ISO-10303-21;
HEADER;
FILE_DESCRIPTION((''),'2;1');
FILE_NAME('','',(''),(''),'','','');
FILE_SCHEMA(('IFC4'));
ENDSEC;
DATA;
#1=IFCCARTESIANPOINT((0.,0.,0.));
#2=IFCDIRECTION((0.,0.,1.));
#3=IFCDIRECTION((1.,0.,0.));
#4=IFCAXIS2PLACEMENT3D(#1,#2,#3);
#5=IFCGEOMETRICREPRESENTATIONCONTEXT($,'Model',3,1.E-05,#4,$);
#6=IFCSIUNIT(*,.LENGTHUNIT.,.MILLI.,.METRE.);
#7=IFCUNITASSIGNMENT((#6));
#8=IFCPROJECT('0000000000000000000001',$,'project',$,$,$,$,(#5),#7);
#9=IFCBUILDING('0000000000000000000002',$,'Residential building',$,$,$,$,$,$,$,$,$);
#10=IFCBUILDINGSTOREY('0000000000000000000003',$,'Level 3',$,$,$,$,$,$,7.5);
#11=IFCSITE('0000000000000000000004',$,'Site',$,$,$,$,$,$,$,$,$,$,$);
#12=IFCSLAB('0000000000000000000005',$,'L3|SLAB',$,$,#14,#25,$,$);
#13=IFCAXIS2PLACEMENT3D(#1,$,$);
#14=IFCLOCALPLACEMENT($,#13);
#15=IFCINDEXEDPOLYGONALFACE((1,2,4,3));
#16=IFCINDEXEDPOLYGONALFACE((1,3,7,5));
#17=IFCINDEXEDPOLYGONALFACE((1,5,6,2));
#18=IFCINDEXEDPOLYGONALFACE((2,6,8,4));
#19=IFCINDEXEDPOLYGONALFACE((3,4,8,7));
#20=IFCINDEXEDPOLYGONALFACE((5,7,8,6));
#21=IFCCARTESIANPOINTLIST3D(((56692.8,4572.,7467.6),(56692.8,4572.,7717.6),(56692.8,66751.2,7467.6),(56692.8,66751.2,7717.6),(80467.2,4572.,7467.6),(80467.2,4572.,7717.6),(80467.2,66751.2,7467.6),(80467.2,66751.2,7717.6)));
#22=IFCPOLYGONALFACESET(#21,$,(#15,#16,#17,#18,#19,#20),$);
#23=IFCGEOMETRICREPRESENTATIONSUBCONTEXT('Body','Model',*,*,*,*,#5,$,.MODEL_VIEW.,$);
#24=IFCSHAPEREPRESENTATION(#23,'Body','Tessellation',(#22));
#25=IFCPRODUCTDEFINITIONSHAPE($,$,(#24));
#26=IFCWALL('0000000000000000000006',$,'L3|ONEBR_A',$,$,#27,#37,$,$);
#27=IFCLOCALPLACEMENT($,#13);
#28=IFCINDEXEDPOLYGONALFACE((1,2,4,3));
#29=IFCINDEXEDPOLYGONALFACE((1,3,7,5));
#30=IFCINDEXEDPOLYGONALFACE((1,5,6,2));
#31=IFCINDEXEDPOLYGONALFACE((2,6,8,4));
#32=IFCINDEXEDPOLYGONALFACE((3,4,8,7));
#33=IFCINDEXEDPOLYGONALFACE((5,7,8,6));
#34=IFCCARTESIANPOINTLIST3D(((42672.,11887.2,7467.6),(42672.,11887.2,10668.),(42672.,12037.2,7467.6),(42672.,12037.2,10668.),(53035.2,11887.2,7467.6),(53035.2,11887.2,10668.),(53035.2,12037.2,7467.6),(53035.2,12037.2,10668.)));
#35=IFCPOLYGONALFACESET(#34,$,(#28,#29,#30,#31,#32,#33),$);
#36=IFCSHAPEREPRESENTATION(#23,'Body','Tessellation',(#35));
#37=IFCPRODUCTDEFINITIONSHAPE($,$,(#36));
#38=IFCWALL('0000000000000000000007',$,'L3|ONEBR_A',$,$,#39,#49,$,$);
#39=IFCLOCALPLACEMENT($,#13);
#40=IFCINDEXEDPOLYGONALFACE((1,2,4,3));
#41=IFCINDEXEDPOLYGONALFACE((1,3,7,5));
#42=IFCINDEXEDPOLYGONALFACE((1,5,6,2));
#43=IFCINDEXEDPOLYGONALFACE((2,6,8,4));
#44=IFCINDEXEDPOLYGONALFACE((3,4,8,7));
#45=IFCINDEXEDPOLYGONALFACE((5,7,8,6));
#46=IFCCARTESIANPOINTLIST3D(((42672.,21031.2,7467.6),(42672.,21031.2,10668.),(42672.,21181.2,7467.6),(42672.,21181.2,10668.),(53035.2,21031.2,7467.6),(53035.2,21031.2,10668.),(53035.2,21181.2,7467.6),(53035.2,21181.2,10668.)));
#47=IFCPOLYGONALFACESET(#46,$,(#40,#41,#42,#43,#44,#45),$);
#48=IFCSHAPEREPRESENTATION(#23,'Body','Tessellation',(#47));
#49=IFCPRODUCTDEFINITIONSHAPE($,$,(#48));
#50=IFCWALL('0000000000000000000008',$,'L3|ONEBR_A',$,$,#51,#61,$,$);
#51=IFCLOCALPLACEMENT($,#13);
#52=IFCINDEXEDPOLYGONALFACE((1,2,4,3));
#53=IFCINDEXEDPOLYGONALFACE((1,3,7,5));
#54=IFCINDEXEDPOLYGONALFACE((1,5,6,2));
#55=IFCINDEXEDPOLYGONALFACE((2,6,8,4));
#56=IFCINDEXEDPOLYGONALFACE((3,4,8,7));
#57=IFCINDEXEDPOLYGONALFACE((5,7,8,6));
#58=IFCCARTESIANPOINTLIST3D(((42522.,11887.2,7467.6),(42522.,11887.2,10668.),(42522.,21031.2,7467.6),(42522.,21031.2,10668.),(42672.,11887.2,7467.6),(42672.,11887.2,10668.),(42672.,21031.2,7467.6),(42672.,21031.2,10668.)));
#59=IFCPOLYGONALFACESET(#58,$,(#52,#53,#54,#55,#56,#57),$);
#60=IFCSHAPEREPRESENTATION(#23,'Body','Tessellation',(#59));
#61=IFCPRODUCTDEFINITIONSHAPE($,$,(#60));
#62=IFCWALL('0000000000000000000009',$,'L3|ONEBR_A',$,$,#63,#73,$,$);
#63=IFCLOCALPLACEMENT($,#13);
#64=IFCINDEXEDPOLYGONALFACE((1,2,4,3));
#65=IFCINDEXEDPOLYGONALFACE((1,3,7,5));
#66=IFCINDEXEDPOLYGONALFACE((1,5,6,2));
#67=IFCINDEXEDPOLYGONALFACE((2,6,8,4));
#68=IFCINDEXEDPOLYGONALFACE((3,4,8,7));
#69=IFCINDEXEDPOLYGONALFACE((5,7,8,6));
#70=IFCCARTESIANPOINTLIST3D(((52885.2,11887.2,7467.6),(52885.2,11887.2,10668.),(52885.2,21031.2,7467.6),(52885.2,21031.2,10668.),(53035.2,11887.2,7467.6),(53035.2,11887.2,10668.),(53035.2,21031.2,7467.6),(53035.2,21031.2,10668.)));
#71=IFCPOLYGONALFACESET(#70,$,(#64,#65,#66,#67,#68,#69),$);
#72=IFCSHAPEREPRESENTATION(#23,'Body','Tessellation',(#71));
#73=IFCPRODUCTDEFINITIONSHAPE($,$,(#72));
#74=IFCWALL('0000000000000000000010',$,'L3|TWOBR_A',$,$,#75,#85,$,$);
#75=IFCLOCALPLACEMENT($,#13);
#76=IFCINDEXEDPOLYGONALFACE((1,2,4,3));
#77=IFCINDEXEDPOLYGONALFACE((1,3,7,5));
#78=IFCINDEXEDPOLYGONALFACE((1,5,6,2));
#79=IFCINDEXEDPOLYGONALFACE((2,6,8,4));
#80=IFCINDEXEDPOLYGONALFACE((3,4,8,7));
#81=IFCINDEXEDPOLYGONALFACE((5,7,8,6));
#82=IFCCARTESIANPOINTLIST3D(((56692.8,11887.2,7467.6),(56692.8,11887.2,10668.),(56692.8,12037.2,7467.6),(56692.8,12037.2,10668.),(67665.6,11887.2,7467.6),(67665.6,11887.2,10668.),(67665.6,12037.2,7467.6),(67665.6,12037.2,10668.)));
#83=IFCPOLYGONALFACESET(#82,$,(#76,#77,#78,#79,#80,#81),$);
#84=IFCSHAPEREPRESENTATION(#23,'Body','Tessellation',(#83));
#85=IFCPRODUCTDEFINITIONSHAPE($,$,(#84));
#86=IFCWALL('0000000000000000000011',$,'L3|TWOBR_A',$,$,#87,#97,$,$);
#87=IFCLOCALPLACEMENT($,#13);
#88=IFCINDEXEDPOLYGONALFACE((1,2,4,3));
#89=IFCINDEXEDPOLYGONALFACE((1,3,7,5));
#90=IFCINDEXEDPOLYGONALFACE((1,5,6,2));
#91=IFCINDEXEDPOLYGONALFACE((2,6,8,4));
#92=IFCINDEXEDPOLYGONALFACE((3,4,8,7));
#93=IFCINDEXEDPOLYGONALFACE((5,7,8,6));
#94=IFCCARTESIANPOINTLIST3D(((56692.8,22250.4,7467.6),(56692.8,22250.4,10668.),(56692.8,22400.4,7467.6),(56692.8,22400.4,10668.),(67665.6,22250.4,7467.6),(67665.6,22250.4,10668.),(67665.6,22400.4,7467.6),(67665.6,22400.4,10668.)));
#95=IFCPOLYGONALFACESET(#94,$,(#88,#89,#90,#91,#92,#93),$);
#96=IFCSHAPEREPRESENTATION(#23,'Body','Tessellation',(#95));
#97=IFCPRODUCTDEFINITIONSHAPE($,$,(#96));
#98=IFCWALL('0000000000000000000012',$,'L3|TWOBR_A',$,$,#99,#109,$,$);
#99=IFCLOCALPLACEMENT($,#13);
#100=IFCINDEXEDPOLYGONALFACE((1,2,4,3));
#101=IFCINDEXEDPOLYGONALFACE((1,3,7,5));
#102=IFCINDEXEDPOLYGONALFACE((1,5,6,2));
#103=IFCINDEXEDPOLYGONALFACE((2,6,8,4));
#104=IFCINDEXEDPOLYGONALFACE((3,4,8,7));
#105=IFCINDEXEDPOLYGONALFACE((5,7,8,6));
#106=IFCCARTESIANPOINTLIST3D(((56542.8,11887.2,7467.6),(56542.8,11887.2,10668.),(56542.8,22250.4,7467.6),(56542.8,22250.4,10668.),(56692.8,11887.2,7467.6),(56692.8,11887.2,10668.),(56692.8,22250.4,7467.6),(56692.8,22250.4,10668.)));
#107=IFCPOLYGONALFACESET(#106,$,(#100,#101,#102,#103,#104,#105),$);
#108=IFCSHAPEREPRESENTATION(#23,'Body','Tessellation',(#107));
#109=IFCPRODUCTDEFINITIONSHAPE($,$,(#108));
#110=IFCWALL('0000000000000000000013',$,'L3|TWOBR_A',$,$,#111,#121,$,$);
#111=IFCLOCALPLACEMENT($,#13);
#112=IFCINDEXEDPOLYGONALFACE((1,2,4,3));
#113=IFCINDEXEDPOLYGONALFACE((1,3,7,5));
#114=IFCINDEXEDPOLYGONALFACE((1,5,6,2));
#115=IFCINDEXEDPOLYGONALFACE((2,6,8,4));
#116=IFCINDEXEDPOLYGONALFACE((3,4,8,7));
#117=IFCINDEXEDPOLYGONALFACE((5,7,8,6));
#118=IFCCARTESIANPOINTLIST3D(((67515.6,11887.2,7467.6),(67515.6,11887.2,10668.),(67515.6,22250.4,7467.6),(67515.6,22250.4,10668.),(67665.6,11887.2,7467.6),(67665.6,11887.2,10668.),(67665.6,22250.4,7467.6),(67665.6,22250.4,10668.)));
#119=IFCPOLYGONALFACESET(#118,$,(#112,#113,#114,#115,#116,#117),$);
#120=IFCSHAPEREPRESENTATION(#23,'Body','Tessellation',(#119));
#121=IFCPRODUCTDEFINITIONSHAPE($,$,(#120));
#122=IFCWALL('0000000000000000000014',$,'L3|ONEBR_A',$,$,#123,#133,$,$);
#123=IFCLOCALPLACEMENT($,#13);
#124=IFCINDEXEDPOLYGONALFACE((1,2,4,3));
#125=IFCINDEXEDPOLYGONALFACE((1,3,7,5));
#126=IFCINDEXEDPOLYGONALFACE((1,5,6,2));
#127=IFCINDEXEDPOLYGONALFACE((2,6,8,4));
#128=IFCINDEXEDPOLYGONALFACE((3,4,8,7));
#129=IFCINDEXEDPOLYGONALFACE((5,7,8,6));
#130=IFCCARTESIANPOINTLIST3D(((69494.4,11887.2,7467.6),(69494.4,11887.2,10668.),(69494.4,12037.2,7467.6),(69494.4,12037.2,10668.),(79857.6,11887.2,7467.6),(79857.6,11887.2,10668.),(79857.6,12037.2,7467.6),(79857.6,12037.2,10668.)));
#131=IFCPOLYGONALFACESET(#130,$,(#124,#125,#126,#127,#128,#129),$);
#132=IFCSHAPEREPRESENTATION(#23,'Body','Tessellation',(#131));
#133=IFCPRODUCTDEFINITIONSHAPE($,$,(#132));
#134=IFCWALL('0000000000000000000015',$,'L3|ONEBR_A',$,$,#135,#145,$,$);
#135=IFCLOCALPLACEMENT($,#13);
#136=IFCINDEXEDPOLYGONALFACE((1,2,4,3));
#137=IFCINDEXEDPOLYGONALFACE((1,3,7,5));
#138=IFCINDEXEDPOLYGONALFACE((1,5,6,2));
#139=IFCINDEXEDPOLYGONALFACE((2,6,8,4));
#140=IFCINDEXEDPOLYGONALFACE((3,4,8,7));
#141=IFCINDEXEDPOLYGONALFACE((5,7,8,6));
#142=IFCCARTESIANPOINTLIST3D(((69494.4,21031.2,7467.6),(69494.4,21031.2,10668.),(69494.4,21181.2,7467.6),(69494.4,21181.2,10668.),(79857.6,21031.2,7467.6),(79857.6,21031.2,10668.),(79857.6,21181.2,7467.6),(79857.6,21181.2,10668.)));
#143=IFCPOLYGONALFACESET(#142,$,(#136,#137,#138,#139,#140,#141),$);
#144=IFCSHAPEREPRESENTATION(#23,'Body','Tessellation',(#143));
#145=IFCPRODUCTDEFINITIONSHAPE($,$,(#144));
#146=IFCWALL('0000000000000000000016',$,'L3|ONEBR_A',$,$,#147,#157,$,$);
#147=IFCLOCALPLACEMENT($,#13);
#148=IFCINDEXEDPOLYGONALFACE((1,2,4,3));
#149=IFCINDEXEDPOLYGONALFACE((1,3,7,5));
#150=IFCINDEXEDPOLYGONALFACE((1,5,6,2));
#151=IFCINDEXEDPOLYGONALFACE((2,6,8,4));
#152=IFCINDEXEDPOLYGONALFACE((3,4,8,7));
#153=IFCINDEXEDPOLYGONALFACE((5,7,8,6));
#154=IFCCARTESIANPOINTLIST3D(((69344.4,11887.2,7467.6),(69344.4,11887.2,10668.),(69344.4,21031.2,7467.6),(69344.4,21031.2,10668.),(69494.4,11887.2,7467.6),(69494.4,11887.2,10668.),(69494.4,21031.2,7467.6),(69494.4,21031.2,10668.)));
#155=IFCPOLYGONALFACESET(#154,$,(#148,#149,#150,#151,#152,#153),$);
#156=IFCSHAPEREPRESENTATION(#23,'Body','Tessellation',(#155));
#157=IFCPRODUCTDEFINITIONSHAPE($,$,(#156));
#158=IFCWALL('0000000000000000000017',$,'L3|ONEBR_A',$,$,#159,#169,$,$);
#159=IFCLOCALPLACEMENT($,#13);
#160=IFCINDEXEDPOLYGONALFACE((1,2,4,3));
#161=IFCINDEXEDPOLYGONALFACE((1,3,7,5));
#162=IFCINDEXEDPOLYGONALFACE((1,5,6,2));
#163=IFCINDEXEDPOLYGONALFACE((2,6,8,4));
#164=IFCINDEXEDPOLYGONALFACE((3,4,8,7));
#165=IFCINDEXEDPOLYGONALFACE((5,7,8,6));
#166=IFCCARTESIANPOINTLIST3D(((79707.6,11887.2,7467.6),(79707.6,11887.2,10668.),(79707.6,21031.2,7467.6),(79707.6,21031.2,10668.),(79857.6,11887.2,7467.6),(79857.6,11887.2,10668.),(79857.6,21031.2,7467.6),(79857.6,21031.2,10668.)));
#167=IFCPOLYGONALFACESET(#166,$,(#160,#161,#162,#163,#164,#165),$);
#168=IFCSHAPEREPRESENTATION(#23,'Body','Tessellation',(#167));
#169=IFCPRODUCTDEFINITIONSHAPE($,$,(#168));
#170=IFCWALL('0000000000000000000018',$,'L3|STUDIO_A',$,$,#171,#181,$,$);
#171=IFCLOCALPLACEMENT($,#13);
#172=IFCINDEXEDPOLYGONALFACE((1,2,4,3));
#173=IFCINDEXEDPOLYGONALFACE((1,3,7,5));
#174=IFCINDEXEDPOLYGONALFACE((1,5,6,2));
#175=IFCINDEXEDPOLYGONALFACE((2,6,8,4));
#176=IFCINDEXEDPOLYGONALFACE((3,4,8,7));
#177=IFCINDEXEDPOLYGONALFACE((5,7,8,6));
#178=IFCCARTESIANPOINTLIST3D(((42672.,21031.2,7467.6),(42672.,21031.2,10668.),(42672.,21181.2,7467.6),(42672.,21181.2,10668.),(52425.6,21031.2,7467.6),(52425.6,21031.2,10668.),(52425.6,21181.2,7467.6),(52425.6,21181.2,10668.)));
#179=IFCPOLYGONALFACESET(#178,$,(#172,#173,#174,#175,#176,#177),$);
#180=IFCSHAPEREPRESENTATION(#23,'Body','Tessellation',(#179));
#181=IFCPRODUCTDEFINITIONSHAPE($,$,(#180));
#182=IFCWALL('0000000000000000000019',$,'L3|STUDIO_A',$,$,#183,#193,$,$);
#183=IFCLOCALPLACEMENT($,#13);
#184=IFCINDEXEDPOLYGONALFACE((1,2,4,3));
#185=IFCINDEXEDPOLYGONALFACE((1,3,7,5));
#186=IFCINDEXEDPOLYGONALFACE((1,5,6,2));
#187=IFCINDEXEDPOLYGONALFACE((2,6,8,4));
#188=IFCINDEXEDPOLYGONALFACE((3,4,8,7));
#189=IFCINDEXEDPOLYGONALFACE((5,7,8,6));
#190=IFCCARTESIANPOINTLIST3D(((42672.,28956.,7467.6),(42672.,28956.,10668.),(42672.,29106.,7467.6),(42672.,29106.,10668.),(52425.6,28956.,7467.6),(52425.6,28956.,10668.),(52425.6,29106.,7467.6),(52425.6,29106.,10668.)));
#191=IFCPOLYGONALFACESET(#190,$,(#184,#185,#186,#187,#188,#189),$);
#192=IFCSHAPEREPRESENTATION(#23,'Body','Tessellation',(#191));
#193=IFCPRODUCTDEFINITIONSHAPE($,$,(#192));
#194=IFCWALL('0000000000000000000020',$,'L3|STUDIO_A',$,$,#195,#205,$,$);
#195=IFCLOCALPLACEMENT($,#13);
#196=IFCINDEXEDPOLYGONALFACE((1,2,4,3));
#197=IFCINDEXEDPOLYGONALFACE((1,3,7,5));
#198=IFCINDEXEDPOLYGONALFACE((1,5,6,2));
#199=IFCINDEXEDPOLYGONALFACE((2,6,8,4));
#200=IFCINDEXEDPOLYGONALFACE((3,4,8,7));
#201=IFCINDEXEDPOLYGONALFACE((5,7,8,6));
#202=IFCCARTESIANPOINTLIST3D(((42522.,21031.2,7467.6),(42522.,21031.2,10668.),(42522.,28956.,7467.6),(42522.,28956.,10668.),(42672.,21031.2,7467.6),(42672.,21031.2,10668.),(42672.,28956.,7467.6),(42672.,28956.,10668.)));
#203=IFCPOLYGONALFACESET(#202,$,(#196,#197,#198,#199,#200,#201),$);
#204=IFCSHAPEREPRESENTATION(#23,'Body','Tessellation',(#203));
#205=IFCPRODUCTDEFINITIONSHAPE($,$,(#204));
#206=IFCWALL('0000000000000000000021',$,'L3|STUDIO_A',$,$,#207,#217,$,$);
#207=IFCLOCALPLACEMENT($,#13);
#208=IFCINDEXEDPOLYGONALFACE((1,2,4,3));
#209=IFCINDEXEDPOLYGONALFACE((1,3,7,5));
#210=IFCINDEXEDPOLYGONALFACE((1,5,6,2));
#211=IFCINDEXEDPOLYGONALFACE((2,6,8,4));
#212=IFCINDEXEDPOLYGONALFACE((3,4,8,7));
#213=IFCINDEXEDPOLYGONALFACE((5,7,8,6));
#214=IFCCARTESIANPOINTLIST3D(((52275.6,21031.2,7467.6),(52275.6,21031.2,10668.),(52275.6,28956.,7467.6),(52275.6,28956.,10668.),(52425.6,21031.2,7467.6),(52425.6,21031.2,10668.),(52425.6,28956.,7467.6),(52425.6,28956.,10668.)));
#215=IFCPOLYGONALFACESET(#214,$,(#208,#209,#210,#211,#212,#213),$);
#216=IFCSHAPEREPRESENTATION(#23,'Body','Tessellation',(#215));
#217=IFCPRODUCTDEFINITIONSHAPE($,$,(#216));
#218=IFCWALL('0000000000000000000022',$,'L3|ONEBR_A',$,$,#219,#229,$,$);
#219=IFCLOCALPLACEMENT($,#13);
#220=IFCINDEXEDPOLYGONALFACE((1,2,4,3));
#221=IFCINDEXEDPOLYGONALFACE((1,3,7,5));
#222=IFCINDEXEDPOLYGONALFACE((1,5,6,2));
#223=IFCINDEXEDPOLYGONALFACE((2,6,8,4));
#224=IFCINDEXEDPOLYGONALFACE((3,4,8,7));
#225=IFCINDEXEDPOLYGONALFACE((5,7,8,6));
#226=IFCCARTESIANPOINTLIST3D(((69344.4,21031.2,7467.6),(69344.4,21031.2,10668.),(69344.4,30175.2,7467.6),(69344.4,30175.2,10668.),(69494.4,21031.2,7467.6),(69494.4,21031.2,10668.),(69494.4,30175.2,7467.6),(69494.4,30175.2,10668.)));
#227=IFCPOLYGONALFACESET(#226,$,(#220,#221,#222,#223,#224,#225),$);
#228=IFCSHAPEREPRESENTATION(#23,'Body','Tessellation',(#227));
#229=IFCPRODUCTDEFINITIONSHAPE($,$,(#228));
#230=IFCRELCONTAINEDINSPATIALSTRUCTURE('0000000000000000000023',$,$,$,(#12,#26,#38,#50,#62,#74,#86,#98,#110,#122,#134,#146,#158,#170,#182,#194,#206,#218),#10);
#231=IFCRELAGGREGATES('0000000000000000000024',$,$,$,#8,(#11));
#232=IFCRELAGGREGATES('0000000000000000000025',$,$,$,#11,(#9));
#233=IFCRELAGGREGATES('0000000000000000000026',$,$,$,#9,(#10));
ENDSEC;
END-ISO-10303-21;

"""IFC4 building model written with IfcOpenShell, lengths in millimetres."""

from ifc_helpers import new_model, si_unit, frame, origin_with_axes, place, context, subcontext, project, spatial, indexed_curve, outline, extrude, element, save


model = new_model("IFC4")

# Units and contexts
model_context = context("Model", 3, precision=1e-05, world=origin_with_axes())
body_context = subcontext(model_context, "Body", "Model", "MODEL_VIEW")
ifc_project = project(units=[si_unit("LENGTHUNIT", "METRE", prefix="MILLI")], contexts=[model_context])

# Site, building, storey
site = spatial("IfcSite", under=ifc_project, Name="Site")
building = spatial("IfcBuilding", under=site, Name="Residential building")
storey = spatial("IfcBuildingStorey", under=building, Name="Level 3", Elevation=7.5)

# Slab
slab_placement = place(None, frame((56692.8, 4572.0, 7467.6), z_axis=(0.0, 0.0, 1.0), x_axis=(1.0, 0.0, 0.0)))
element("IfcSlab", 1, at=slab_placement, inside=storey, Name="L3|SLAB", context=body_context, shape_type="SweptSolid", body=[
    extrude(outline(indexed_curve([(0.0, 0.0), (23774.4, 0.0), (23774.4, 62179.2), (0.0, 62179.2), (0.0, 0.0)])), None, (0.0, 0.0, 1.0), 250.0),
])

# Walls
for number, where, z_axis, x_axis, name in (
    (2, (42672.0, 11887.2, 7467.6), (0.0, 0.0, 1.0), (1.0, 0.0, 0.0), "L3|ONEBR_A"),
    (3, (42672.0, 21031.2, 7467.6), (0.0, 0.0, 1.0), (1.0, 0.0, 0.0), "L3|ONEBR_A"),
):
    element("IfcWall", number, at=place(None, frame(where, z_axis=z_axis, x_axis=x_axis)), inside=storey, Name=name, context=body_context, shape_type="SweptSolid", body=[
        extrude(outline(indexed_curve([(0.0, 0.0), (0.0, 150.0), (10363.2, 150.0), (10363.2, 0.0), (0.0, 0.0)], self_intersect=False)), origin_with_axes(), (0.0, 0.0, 1.0), 3200.4),
    ])
for number, where, z_axis, x_axis, name in (
    (4, (42672.0, 11887.2, 7467.6), (0.0, 0.0, 1.0), (0.0, 1.0, 0.0), "L3|ONEBR_A"),
    (5, (53035.2, 11887.2, 7467.6), (0.0, 0.0, 1.0), (0.0, 1.0, 0.0), "L3|ONEBR_A"),
):
    element("IfcWall", number, at=place(None, frame(where, z_axis=z_axis, x_axis=x_axis)), inside=storey, Name=name, context=body_context, shape_type="SweptSolid", body=[
        extrude(outline(indexed_curve([(0.0, 0.0), (0.0, 150.0), (9144.0, 150.0), (9144.0, 0.0), (0.0, 0.0)], self_intersect=False)), origin_with_axes(), (0.0, 0.0, 1.0), 3200.4),
    ])
for number, where, z_axis, x_axis, name in (
    (6, (56692.8, 11887.2, 7467.6), (0.0, 0.0, 1.0), (1.0, 0.0, 0.0), "L3|TWOBR_A"),
    (7, (56692.8, 22250.4, 7467.6), (0.0, 0.0, 1.0), (1.0, 0.0, 0.0), "L3|TWOBR_A"),
):
    element("IfcWall", number, at=place(None, frame(where, z_axis=z_axis, x_axis=x_axis)), inside=storey, Name=name, context=body_context, shape_type="SweptSolid", body=[
        extrude(outline(indexed_curve([(0.0, 0.0), (0.0, 150.0), (10972.8, 150.0), (10972.8, 0.0), (0.0, 0.0)], self_intersect=False)), origin_with_axes(), (0.0, 0.0, 1.0), 3200.4),
    ])
for number, where, z_axis, x_axis, name in (
    (8, (56692.8, 11887.2, 7467.6), (0.0, 0.0, 1.0), (0.0, 1.0, 0.0), "L3|TWOBR_A"),
    (9, (67665.6, 11887.2, 7467.6), (0.0, 0.0, 1.0), (0.0, 1.0, 0.0), "L3|TWOBR_A"),
    (10, (69494.4, 11887.2, 7467.6), (0.0, 0.0, 1.0), (1.0, 0.0, 0.0), "L3|ONEBR_A"),
    (11, (69494.4, 21031.2, 7467.6), (0.0, 0.0, 1.0), (1.0, 0.0, 0.0), "L3|ONEBR_A"),
):
    element("IfcWall", number, at=place(None, frame(where, z_axis=z_axis, x_axis=x_axis)), inside=storey, Name=name, context=body_context, shape_type="SweptSolid", body=[
        extrude(outline(indexed_curve([(0.0, 0.0), (0.0, 150.0), (10363.2, 150.0), (10363.2, 0.0), (0.0, 0.0)], self_intersect=False)), origin_with_axes(), (0.0, 0.0, 1.0), 3200.4),
    ])
for number, where, z_axis, x_axis, name in (
    (12, (69494.4, 11887.2, 7467.6), (0.0, 0.0, 1.0), (0.0, 1.0, 0.0), "L3|ONEBR_A"),
    (13, (79857.6, 11887.2, 7467.6), (0.0, 0.0, 1.0), (0.0, 1.0, 0.0), "L3|ONEBR_A"),
):
    element("IfcWall", number, at=place(None, frame(where, z_axis=z_axis, x_axis=x_axis)), inside=storey, Name=name, context=body_context, shape_type="SweptSolid", body=[
        extrude(outline(indexed_curve([(0.0, 0.0), (0.0, 150.0), (9144.0, 150.0), (9144.0, 0.0), (0.0, 0.0)], self_intersect=False)), origin_with_axes(), (0.0, 0.0, 1.0), 3200.4),
    ])
for number, where, z_axis, x_axis, name in (
    (14, (42672.0, 21031.2, 7467.6), (0.0, 0.0, 1.0), (1.0, 0.0, 0.0), "L3|STUDIO_A"),
    (15, (42672.0, 28956.0, 7467.6), (0.0, 0.0, 1.0), (1.0, 0.0, 0.0), "L3|STUDIO_A"),
):
    element("IfcWall", number, at=place(None, frame(where, z_axis=z_axis, x_axis=x_axis)), inside=storey, Name=name, context=body_context, shape_type="SweptSolid", body=[
        extrude(outline(indexed_curve([(0.0, 0.0), (0.0, 150.0), (9753.6, 150.0), (9753.6, 0.0), (0.0, 0.0)], self_intersect=False)), origin_with_axes(), (0.0, 0.0, 1.0), 3200.4),
    ])
for number, where, z_axis, x_axis, name in (
    (16, (42672.0, 21031.2, 7467.6), (0.0, 0.0, 1.0), (0.0, 1.0, 0.0), "L3|STUDIO_A"),
    (17, (52425.6, 21031.2, 7467.6), (0.0, 0.0, 1.0), (0.0, 1.0, 0.0), "L3|STUDIO_A"),
):
    element("IfcWall", number, at=place(None, frame(where, z_axis=z_axis, x_axis=x_axis)), inside=storey, Name=name, context=body_context, shape_type="SweptSolid", body=[
        extrude(outline(indexed_curve([(0.0, 0.0), (0.0, 150.0), (7924.8, 150.0), (7924.8, 0.0), (0.0, 0.0)], self_intersect=False)), origin_with_axes(), (0.0, 0.0, 1.0), 3200.4),
    ])
for number, where, z_axis, x_axis, name in (
    (18, (69494.4, 21031.2, 7467.6), (0.0, 0.0, 1.0), (0.0, 1.0, 0.0), "L3|ONEBR_A"),
):
    element("IfcWall", number, at=place(None, frame(where, z_axis=z_axis, x_axis=x_axis)), inside=storey, Name=name, context=body_context, shape_type="SweptSolid", body=[
        extrude(outline(indexed_curve([(0.0, 0.0), (0.0, 150.0), (9144.0, 150.0), (9144.0, 0.0), (0.0, 0.0)], self_intersect=False)), origin_with_axes(), (0.0, 0.0, 1.0), 3200.4),
    ])

save(model, "model.ifc")
